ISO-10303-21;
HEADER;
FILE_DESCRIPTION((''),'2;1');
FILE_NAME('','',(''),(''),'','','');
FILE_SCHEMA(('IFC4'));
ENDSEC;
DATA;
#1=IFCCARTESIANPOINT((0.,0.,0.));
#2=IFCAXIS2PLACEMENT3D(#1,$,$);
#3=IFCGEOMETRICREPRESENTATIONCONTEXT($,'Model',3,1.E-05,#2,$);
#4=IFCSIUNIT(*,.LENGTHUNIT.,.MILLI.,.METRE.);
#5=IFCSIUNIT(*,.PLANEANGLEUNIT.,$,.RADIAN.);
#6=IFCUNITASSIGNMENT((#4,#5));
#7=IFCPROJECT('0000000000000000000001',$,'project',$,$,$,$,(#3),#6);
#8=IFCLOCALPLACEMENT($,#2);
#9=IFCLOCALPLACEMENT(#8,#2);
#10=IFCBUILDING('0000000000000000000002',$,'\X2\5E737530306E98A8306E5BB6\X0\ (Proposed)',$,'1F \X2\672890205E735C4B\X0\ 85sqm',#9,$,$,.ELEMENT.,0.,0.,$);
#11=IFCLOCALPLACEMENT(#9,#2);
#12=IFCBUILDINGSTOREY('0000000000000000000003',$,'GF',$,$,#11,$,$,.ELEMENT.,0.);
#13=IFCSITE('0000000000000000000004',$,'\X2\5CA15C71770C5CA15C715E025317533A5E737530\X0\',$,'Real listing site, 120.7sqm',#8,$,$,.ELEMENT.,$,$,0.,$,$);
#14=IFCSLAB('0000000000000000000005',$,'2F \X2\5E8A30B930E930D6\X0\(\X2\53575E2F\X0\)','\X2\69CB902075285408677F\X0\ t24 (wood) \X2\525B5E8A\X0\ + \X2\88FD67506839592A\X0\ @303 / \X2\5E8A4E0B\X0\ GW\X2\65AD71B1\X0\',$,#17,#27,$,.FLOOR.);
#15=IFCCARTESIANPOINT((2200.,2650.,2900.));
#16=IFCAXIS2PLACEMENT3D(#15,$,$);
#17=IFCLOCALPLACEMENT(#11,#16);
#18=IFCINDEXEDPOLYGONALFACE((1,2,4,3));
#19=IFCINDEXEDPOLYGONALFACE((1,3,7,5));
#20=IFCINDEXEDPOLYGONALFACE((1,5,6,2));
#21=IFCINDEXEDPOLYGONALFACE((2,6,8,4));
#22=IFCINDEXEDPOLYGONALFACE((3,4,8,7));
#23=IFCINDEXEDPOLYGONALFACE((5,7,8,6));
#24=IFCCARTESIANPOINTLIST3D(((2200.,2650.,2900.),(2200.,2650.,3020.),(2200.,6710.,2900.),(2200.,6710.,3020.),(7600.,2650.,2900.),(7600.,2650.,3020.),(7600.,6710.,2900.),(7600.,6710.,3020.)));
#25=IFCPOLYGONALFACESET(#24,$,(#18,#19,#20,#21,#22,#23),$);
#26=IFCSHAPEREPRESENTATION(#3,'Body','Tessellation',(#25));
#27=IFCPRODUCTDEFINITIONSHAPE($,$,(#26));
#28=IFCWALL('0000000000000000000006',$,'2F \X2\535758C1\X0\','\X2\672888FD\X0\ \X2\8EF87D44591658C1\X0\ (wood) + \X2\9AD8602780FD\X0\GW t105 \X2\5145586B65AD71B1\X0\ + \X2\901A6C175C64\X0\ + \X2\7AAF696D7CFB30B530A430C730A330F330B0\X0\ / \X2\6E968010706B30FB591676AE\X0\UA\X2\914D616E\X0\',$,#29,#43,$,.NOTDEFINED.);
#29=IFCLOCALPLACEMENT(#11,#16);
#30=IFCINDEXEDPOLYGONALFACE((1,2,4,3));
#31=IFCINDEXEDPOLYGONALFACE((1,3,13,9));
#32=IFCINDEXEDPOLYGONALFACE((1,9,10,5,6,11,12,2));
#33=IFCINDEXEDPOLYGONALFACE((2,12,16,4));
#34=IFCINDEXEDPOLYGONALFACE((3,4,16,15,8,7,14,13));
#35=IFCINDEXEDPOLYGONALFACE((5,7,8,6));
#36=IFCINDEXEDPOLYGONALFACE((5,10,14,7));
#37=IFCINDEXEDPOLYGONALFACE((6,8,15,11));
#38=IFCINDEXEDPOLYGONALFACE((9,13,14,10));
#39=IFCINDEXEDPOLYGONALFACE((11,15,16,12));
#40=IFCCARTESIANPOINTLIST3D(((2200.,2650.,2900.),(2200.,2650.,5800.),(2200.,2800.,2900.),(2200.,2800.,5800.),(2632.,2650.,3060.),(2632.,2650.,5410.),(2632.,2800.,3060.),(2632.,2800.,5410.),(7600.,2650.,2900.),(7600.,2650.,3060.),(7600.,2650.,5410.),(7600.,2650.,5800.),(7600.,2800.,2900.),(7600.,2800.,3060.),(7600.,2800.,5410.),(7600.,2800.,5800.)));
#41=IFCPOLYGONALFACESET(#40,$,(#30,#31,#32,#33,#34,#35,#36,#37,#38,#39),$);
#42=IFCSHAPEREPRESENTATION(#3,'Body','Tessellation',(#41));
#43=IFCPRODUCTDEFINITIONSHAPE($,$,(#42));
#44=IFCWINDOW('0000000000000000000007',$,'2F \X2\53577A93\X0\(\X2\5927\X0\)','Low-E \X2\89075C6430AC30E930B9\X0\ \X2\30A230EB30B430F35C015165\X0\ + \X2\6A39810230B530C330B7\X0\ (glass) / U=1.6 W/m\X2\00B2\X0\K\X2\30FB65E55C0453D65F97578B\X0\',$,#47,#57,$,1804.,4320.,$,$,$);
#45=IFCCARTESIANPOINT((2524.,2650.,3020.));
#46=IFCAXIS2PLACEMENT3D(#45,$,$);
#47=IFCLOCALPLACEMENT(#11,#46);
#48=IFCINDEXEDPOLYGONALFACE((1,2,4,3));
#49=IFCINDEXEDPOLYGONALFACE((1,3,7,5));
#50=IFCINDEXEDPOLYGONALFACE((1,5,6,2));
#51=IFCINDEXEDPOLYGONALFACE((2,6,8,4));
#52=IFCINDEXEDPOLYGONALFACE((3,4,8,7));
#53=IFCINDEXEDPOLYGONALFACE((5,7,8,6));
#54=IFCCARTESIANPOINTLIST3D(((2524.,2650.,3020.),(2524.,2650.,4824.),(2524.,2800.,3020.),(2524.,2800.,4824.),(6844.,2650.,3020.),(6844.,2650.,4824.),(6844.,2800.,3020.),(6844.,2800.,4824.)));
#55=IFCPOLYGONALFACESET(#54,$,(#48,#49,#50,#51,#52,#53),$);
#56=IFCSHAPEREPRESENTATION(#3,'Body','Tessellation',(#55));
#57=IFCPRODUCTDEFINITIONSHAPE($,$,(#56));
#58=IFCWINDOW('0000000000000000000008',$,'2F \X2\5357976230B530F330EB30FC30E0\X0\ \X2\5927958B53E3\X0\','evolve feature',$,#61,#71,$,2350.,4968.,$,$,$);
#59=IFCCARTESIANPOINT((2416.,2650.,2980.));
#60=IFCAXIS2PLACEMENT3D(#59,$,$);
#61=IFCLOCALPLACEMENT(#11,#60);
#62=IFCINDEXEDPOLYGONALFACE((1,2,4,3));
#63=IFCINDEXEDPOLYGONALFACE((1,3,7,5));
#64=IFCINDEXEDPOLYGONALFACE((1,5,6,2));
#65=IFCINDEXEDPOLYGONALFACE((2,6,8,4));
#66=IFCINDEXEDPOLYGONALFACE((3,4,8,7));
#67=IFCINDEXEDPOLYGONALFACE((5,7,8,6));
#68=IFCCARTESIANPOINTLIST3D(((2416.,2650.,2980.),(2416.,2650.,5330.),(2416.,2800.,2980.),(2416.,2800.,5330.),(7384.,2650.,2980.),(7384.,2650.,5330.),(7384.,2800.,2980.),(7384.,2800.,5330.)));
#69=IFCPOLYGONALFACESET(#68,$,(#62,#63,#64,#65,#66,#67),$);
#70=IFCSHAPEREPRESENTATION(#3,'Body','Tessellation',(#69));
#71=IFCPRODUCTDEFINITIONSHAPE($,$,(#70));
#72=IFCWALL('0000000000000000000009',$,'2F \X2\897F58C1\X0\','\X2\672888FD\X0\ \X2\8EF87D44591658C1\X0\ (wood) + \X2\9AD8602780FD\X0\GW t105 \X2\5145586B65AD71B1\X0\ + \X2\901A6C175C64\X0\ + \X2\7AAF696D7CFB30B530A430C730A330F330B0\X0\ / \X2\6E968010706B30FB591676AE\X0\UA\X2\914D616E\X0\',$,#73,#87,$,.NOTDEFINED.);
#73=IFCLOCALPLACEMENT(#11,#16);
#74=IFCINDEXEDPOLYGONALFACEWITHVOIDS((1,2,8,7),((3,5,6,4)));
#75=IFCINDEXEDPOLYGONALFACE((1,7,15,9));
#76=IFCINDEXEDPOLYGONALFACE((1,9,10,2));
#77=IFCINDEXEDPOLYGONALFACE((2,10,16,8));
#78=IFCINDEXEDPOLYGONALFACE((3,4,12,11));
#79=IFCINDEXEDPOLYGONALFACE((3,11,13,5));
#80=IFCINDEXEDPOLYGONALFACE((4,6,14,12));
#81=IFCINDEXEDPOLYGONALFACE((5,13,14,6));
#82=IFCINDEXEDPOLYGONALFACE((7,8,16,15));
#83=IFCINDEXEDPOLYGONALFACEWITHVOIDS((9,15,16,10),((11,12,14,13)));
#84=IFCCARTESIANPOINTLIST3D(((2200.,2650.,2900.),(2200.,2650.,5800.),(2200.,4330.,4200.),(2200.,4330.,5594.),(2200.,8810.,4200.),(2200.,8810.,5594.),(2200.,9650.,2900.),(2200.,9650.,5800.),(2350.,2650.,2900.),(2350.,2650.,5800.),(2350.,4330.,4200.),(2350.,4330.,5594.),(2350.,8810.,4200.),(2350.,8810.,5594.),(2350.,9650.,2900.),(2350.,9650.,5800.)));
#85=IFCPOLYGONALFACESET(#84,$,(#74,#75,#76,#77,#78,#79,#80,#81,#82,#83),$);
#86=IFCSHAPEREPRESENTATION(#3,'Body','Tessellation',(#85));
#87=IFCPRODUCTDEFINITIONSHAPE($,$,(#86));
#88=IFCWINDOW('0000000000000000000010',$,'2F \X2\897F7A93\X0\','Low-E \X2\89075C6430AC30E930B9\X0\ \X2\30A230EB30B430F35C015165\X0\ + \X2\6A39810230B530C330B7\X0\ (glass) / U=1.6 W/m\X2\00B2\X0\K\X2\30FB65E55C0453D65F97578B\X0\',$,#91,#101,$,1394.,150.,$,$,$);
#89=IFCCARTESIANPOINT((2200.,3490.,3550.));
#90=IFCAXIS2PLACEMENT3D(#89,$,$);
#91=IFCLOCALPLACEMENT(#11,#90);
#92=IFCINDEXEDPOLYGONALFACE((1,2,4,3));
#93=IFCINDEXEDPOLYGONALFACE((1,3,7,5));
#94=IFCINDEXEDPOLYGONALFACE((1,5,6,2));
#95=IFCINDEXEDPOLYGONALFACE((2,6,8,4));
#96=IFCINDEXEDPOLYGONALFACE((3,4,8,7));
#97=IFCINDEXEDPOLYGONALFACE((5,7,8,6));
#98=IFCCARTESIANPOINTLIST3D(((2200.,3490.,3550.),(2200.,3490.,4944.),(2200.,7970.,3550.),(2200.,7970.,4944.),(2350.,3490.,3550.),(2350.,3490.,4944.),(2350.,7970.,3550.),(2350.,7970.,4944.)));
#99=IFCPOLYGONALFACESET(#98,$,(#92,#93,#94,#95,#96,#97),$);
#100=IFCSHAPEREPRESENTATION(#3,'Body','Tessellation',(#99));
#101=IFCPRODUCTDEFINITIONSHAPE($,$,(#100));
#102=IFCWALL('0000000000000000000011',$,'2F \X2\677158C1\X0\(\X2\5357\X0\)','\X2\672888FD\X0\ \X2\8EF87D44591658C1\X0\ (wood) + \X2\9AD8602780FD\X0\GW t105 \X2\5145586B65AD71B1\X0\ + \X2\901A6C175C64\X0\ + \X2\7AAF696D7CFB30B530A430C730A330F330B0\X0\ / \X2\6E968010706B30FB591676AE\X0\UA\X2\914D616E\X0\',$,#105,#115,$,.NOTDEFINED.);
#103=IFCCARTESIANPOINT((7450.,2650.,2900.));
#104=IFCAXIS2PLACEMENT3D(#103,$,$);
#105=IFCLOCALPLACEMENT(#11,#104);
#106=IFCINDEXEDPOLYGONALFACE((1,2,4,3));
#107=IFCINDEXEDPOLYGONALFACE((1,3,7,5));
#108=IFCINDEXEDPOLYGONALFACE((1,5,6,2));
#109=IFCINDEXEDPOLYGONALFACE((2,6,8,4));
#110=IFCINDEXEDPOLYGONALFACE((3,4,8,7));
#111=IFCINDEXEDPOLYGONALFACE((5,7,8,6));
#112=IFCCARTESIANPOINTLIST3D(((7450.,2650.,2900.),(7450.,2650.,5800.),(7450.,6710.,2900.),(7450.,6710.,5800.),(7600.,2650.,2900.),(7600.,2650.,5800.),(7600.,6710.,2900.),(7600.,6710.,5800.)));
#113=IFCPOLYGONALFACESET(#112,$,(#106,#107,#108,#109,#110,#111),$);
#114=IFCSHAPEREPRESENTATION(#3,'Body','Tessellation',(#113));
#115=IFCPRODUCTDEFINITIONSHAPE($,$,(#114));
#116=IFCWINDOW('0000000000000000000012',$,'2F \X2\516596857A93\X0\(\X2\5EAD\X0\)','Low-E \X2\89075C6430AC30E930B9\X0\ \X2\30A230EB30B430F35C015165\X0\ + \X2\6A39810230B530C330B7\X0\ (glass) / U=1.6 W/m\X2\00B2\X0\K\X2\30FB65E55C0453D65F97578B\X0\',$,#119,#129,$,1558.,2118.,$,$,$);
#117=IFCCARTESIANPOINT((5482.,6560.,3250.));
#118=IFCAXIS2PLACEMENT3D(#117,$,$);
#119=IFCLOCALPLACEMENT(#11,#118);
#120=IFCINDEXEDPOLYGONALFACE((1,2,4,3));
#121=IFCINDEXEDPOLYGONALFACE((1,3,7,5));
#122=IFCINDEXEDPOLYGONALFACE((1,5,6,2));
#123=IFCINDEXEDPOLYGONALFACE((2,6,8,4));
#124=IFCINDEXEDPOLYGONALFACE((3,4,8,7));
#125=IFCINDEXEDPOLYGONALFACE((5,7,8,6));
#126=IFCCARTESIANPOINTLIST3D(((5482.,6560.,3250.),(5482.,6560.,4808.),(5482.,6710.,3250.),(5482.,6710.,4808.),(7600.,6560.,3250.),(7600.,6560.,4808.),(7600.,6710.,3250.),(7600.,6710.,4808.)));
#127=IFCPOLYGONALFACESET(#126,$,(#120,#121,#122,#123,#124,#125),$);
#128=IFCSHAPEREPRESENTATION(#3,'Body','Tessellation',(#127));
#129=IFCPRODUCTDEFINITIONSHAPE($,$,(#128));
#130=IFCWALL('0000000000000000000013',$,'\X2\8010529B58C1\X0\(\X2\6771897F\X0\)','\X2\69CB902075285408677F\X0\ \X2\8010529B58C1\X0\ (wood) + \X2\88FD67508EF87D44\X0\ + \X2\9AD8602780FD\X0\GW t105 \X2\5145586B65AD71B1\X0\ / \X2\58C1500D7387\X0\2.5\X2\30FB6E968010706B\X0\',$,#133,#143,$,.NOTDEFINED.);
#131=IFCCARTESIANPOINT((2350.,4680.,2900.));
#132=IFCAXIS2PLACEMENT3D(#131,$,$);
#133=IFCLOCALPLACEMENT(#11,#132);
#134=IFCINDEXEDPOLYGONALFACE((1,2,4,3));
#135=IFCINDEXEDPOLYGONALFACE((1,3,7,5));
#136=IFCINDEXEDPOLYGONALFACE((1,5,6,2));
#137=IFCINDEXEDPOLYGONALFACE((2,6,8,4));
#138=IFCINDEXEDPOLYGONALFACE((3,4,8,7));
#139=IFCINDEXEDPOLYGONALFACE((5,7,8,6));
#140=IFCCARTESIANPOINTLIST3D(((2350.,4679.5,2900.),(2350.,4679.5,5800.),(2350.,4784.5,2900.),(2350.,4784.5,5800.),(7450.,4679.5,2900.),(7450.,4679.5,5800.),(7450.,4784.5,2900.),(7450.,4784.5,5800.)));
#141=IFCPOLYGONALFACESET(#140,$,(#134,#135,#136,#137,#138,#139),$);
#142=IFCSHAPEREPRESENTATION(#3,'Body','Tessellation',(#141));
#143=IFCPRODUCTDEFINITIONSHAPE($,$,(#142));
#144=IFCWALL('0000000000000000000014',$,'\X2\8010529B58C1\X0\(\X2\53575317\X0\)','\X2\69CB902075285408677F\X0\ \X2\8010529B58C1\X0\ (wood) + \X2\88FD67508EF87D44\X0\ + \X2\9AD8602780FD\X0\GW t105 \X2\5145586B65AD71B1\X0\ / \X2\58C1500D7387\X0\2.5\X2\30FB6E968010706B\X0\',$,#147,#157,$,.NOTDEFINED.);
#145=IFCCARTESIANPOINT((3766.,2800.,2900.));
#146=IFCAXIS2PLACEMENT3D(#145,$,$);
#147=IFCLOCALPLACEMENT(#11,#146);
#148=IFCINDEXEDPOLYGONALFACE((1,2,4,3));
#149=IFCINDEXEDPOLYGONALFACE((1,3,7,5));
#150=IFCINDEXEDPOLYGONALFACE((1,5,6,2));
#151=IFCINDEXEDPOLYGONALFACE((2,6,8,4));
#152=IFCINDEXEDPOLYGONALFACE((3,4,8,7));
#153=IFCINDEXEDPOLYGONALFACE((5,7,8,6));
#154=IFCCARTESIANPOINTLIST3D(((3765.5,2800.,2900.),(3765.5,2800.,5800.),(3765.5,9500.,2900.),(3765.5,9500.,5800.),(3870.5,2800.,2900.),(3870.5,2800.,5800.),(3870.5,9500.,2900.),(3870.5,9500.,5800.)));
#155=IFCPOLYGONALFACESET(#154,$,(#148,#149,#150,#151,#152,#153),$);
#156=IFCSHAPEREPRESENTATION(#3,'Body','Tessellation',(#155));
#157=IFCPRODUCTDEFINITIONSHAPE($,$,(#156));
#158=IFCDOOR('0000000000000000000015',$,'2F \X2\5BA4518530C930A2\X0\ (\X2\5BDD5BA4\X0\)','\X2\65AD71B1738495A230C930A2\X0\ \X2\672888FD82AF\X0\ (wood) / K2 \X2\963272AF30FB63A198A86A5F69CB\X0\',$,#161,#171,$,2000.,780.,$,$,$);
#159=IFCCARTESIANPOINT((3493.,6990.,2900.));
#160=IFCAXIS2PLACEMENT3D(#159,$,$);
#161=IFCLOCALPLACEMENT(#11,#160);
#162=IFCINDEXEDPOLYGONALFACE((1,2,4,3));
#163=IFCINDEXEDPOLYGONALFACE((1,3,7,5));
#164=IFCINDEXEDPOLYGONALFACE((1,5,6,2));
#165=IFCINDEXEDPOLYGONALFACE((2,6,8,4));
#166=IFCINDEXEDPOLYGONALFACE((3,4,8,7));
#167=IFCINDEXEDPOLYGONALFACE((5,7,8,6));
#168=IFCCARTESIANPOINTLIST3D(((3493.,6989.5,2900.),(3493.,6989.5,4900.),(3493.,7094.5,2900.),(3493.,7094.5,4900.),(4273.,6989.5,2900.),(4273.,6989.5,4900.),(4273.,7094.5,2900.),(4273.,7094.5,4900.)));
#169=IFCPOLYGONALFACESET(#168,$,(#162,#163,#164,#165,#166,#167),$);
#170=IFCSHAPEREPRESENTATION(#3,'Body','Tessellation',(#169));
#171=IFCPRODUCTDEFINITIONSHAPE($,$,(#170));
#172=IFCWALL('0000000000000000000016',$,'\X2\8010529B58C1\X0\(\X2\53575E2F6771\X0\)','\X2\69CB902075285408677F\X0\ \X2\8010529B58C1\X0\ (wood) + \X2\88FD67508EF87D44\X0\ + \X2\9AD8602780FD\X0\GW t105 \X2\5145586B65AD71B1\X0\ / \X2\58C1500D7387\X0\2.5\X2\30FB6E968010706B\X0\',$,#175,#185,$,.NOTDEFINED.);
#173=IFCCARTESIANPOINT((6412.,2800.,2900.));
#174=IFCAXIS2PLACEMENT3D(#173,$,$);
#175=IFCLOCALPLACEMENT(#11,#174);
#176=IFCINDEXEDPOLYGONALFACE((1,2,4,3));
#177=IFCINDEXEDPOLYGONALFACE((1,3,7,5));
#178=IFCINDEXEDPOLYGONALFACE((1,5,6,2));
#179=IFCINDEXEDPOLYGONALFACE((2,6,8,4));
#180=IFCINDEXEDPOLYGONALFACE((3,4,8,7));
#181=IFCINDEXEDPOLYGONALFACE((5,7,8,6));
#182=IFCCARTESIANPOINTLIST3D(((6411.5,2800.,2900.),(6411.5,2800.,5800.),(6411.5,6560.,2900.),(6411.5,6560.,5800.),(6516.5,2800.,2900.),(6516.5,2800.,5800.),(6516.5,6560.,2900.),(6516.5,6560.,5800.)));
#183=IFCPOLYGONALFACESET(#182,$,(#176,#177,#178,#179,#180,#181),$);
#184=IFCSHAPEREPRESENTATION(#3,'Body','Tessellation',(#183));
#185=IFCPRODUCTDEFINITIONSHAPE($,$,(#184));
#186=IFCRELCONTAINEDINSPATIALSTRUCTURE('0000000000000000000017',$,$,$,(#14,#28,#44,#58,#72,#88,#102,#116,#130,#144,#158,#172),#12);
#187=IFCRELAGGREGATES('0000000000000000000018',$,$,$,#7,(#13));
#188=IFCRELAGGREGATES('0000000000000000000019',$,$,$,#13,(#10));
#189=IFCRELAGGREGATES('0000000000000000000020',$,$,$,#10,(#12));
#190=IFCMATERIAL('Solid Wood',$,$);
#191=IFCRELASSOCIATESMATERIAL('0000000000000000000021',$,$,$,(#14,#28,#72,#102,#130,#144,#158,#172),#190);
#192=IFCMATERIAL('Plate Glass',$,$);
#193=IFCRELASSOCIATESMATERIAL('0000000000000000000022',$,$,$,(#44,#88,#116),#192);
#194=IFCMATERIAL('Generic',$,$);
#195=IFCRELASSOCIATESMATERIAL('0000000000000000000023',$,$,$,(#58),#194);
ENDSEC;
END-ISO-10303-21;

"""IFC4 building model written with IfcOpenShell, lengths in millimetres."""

from ifc_helpers import new_model, si_unit, frame, frame_2d, origin, place, context, project, spatial, rectangle, extrude, material, element, fill, save


model = new_model("IFC4")

# Units and contexts
model_context = context("Model", 3, precision=1e-05, world=origin())
ifc_project = project(units=[si_unit("LENGTHUNIT", "METRE", prefix="MILLI"), si_unit("PLANEANGLEUNIT", "RADIAN")], contexts=[model_context])

# Site, building, storey
site_placement = place(None, origin())
site = spatial("IfcSite", under=ifc_project, at=site_placement, Name="岡山県岡山市北区平田", ObjectType="Real listing site, 120.7sqm", CompositionType="ELEMENT", RefElevation=0.0)
building_placement = place(site_placement, origin())
building = spatial("IfcBuilding", under=site, at=building_placement, Name="平田の風の家 (Proposed)", ObjectType="1F 木造平屋 85sqm", CompositionType="ELEMENT", ElevationOfRefHeight=0.0, ElevationOfTerrain=0.0)
storey_placement = place(building_placement, origin())
storey = spatial("IfcBuildingStorey", under=building, at=storey_placement, Name="GF", CompositionType="ELEMENT", Elevation=0.0)

# Slab
ifc_material_1 = material(Name="Solid Wood")
slab_placement = place(storey_placement, frame((2200.0, 2650.0, 2900.0)))
element("IfcSlab", 1, at=slab_placement, inside=storey, material=ifc_material_1, Name="2F 床スラブ(南帯)", Description="構造用合板 t24 (wood) 剛床 + 製材根太 @303 / 床下 GW断熱", PredefinedType="FLOOR", context=model_context, shape_type="SweptSolid", body=[
    extrude(rectangle(XDim=5400.0, YDim=4060.0, at=frame_2d((2700.0, 2030.0))), frame((2200.0, 2650.0, 2900.0)), (0.0, 0.0, 1.0), 120.0),
])

# Wall, openings, windows
wall_1_placement = place(storey_placement, frame((2200.0, 2650.0, 2900.0)))
wall_1 = element("IfcWall", 2, at=wall_1_placement, inside=storey, material=ifc_material_1, Name="2F 南壁", Description="木製 軸組外壁 (wood) + 高性能GW t105 充填断熱 + 通気層 + 窯業系サイディング / 準耐火・外皮UA配慮", PredefinedType="NOTDEFINED", context=model_context, shape_type="SweptSolid", body=[
    extrude(rectangle(XDim=5400.0, YDim=150.0, at=frame_2d((2700.0, 75.0))), frame((2200.0, 2650.0, 2900.0)), (0.0, 0.0, 1.0), 2900.0),
])
opening_1_placement = place(storey_placement, frame((2524.0, 2650.0, 3020.0)))
opening_1 = element("IfcOpeningElement", 3, at=opening_1_placement, cuts=wall_1, PredefinedType="NOTDEFINED", context=model_context, shape_type="SweptSolid", body=[
    extrude(rectangle(XDim=4320.0, YDim=150.0, at=frame_2d((2160.0, 75.0))), frame((2524.0, 2650.0, 3020.0)), (0.0, 0.0, 1.0), 1804.0),
])
opening_2_placement = place(storey_placement, frame((2416.0, 2650.0, 2980.0)))
opening_2 = element("IfcOpeningElement", 4, at=opening_2_placement, cuts=wall_1, PredefinedType="NOTDEFINED", context=model_context, shape_type="SweptSolid", body=[
    extrude(rectangle(XDim=4968.0, YDim=150.0, at=frame_2d((2484.0, 75.0))), frame((2416.0, 2650.0, 2980.0)), (0.0, 0.0, 1.0), 2350.0),
])
ifc_material_2 = material(Name="Plate Glass")
window_1_placement = place(storey_placement, frame((2524.0, 2650.0, 3020.0)))
window_1 = element("IfcWindow", 5, at=window_1_placement, inside=storey, material=ifc_material_2, Name="2F 南窓(大)", Description="Low-E 複層ガラス アルゴン封入 + 樹脂サッシ (glass) / U=1.6 W/m²K・日射取得型", OverallHeight=1804.0, OverallWidth=4320.0, context=model_context, shape_type="SweptSolid", body=[
    extrude(rectangle(XDim=4320.0, YDim=150.0, at=frame_2d((2160.0, 75.0))), frame((2524.0, 2650.0, 3020.0)), (0.0, 0.0, 1.0), 1804.0),
])
fill(opening_1, window_1)
ifc_material_3 = material(Name="Generic")
window_2_placement = place(storey_placement, frame((2416.0, 2650.0, 2980.0)))
window_2 = element("IfcWindow", 6, at=window_2_placement, inside=storey, material=ifc_material_3, Name="2F 南面サンルーム 大開口", Description="evolve feature", OverallHeight=2350.0, OverallWidth=4968.0, context=model_context, shape_type="SweptSolid", body=[
    extrude(rectangle(XDim=4968.0, YDim=150.0, at=frame_2d((2484.0, 75.0))), frame((2416.0, 2650.0, 2980.0)), (0.0, 0.0, 1.0), 2350.0),
])
fill(opening_2, window_2)

# Walls, openings, windows
wall_2_placement = place(storey_placement, frame((2200.0, 2650.0, 2900.0)))
wall_2 = element("IfcWall", 7, at=wall_2_placement, inside=storey, material=ifc_material_1, Name="2F 西壁", Description="木製 軸組外壁 (wood) + 高性能GW t105 充填断熱 + 通気層 + 窯業系サイディング / 準耐火・外皮UA配慮", PredefinedType="NOTDEFINED", context=model_context, shape_type="SweptSolid", body=[
    extrude(rectangle(XDim=150.0, YDim=7000.0, at=frame_2d((75.0, 3500.0))), frame((2200.0, 2650.0, 2900.0)), (0.0, 0.0, 1.0), 2900.0),
])
opening_3_placement = place(storey_placement, frame((2200.0, 3490.0, 3550.0)))
opening_3 = element("IfcOpeningElement", 8, at=opening_3_placement, cuts=wall_2, PredefinedType="NOTDEFINED", context=model_context, shape_type="SweptSolid", body=[
    extrude(rectangle(XDim=150.0, YDim=4480.0, at=frame_2d((75.0, 2240.0))), frame((2200.0, 3490.0, 3550.0)), (0.0, 0.0, 1.0), 1394.0),
])
window_3_placement = place(storey_placement, frame((2200.0, 3490.0, 3550.0)))
window_3 = element("IfcWindow", 9, at=window_3_placement, inside=storey, material=ifc_material_2, Name="2F 西窓", Description="Low-E 複層ガラス アルゴン封入 + 樹脂サッシ (glass) / U=1.6 W/m²K・日射取得型", OverallHeight=1394.0, OverallWidth=150.0, context=model_context, shape_type="SweptSolid", body=[
    extrude(rectangle(XDim=150.0, YDim=4480.0, at=frame_2d((75.0, 2240.0))), frame((2200.0, 3490.0, 3550.0)), (0.0, 0.0, 1.0), 1394.0),
])
fill(opening_3, window_3)
wall_3_placement = place(storey_placement, frame((7450.0, 2650.0, 2900.0)))
wall_3 = element("IfcWall", 10, at=wall_3_placement, inside=storey, material=ifc_material_1, Name="2F 東壁(南)", Description="木製 軸組外壁 (wood) + 高性能GW t105 充填断熱 + 通気層 + 窯業系サイディング / 準耐火・外皮UA配慮", PredefinedType="NOTDEFINED", context=model_context, shape_type="SweptSolid", body=[
    extrude(rectangle(XDim=150.0, YDim=4060.0, at=frame_2d((75.0, 2030.0))), frame((7450.0, 2650.0, 2900.0)), (0.0, 0.0, 1.0), 2900.0),
])
opening_4_placement = place(storey_placement, frame((5482.0, 6560.0, 3250.0)))
opening_4 = element("IfcOpeningElement", 11, at=opening_4_placement, cuts=wall_3, PredefinedType="NOTDEFINED", context=model_context, shape_type="SweptSolid", body=[
    extrude(rectangle(XDim=2118.0, YDim=150.0, at=frame_2d((1059.0, 75.0))), frame((5482.0, 6560.0, 3250.0)), (0.0, 0.0, 1.0), 1558.0),
])
window_4_placement = place(storey_placement, frame((5482.0, 6560.0, 3250.0)))
window_4 = element("IfcWindow", 12, at=window_4_placement, inside=storey, material=ifc_material_2, Name="2F 入隅窓(庭)", Description="Low-E 複層ガラス アルゴン封入 + 樹脂サッシ (glass) / U=1.6 W/m²K・日射取得型", OverallHeight=1558.0, OverallWidth=2118.0, context=model_context, shape_type="SweptSolid", body=[
    extrude(rectangle(XDim=2118.0, YDim=150.0, at=frame_2d((1059.0, 75.0))), frame((5482.0, 6560.0, 3250.0)), (0.0, 0.0, 1.0), 1558.0),
])
fill(opening_4, window_4)

# Wall
wall_4_placement = place(storey_placement, frame((2350.0, 4680.0, 2900.0)))
element("IfcWall", 13, at=wall_4_placement, inside=storey, material=ifc_material_1, Name="耐力壁(東西)", Description="構造用合板 耐力壁 (wood) + 製材軸組 + 高性能GW t105 充填断熱 / 壁倍率2.5・準耐火", PredefinedType="NOTDEFINED", context=model_context, shape_type="SweptSolid", body=[
    extrude(rectangle(XDim=5100.0, YDim=105.0, at=frame_2d((2550.0, 52.0))), frame((2350.0, 4680.0, 2900.0)), (0.0, 0.0, 1.0), 2900.0),
])

# Wall, opening, door
wall_5_placement = place(storey_placement, frame((3766.0, 2800.0, 2900.0)))
wall_5 = element("IfcWall", 14, at=wall_5_placement, inside=storey, material=ifc_material_1, Name="耐力壁(南北)", Description="構造用合板 耐力壁 (wood) + 製材軸組 + 高性能GW t105 充填断熱 / 壁倍率2.5・準耐火", PredefinedType="NOTDEFINED", context=model_context, shape_type="SweptSolid", body=[
    extrude(rectangle(XDim=105.0, YDim=6700.0, at=frame_2d((52.0, 3350.0))), frame((3766.0, 2800.0, 2900.0)), (0.0, 0.0, 1.0), 2900.0),
])
opening_5_placement = place(storey_placement, frame((3493.0, 6990.0, 2900.0)))
opening_5 = element("IfcOpeningElement", 15, at=opening_5_placement, cuts=wall_5, PredefinedType="NOTDEFINED", context=model_context, shape_type="SweptSolid", body=[
    extrude(rectangle(XDim=780.0, YDim=105.0, at=frame_2d((390.0, 52.0))), frame((3493.0, 6990.0, 2900.0)), (0.0, 0.0, 1.0), 2000.0),
])
door_placement = place(storey_placement, frame((3493.0, 6990.0, 2900.0)))
door = element("IfcDoor", 16, at=door_placement, inside=storey, material=ifc_material_1, Name="2F 室内ドア (寝室)", Description="断熱玄関ドア 木製芯 (wood) / K2 防犯・採風機構", OverallHeight=2000.0, OverallWidth=780.0, context=model_context, shape_type="SweptSolid", body=[
    extrude(rectangle(XDim=780.0, YDim=105.0, at=frame_2d((390.0, 52.0))), frame((3493.0, 6990.0, 2900.0)), (0.0, 0.0, 1.0), 2000.0),
])
fill(opening_5, door)

# Wall
wall_6_placement = place(storey_placement, frame((6412.0, 2800.0, 2900.0)))
element("IfcWall", 17, at=wall_6_placement, inside=storey, material=ifc_material_1, Name="耐力壁(南帯東)", Description="構造用合板 耐力壁 (wood) + 製材軸組 + 高性能GW t105 充填断熱 / 壁倍率2.5・準耐火", PredefinedType="NOTDEFINED", context=model_context, shape_type="SweptSolid", body=[
    extrude(rectangle(XDim=105.0, YDim=3760.0, at=frame_2d((52.0, 1880.0))), frame((6412.0, 2800.0, 2900.0)), (0.0, 0.0, 1.0), 2900.0),
])

save(model, "model.ifc")
